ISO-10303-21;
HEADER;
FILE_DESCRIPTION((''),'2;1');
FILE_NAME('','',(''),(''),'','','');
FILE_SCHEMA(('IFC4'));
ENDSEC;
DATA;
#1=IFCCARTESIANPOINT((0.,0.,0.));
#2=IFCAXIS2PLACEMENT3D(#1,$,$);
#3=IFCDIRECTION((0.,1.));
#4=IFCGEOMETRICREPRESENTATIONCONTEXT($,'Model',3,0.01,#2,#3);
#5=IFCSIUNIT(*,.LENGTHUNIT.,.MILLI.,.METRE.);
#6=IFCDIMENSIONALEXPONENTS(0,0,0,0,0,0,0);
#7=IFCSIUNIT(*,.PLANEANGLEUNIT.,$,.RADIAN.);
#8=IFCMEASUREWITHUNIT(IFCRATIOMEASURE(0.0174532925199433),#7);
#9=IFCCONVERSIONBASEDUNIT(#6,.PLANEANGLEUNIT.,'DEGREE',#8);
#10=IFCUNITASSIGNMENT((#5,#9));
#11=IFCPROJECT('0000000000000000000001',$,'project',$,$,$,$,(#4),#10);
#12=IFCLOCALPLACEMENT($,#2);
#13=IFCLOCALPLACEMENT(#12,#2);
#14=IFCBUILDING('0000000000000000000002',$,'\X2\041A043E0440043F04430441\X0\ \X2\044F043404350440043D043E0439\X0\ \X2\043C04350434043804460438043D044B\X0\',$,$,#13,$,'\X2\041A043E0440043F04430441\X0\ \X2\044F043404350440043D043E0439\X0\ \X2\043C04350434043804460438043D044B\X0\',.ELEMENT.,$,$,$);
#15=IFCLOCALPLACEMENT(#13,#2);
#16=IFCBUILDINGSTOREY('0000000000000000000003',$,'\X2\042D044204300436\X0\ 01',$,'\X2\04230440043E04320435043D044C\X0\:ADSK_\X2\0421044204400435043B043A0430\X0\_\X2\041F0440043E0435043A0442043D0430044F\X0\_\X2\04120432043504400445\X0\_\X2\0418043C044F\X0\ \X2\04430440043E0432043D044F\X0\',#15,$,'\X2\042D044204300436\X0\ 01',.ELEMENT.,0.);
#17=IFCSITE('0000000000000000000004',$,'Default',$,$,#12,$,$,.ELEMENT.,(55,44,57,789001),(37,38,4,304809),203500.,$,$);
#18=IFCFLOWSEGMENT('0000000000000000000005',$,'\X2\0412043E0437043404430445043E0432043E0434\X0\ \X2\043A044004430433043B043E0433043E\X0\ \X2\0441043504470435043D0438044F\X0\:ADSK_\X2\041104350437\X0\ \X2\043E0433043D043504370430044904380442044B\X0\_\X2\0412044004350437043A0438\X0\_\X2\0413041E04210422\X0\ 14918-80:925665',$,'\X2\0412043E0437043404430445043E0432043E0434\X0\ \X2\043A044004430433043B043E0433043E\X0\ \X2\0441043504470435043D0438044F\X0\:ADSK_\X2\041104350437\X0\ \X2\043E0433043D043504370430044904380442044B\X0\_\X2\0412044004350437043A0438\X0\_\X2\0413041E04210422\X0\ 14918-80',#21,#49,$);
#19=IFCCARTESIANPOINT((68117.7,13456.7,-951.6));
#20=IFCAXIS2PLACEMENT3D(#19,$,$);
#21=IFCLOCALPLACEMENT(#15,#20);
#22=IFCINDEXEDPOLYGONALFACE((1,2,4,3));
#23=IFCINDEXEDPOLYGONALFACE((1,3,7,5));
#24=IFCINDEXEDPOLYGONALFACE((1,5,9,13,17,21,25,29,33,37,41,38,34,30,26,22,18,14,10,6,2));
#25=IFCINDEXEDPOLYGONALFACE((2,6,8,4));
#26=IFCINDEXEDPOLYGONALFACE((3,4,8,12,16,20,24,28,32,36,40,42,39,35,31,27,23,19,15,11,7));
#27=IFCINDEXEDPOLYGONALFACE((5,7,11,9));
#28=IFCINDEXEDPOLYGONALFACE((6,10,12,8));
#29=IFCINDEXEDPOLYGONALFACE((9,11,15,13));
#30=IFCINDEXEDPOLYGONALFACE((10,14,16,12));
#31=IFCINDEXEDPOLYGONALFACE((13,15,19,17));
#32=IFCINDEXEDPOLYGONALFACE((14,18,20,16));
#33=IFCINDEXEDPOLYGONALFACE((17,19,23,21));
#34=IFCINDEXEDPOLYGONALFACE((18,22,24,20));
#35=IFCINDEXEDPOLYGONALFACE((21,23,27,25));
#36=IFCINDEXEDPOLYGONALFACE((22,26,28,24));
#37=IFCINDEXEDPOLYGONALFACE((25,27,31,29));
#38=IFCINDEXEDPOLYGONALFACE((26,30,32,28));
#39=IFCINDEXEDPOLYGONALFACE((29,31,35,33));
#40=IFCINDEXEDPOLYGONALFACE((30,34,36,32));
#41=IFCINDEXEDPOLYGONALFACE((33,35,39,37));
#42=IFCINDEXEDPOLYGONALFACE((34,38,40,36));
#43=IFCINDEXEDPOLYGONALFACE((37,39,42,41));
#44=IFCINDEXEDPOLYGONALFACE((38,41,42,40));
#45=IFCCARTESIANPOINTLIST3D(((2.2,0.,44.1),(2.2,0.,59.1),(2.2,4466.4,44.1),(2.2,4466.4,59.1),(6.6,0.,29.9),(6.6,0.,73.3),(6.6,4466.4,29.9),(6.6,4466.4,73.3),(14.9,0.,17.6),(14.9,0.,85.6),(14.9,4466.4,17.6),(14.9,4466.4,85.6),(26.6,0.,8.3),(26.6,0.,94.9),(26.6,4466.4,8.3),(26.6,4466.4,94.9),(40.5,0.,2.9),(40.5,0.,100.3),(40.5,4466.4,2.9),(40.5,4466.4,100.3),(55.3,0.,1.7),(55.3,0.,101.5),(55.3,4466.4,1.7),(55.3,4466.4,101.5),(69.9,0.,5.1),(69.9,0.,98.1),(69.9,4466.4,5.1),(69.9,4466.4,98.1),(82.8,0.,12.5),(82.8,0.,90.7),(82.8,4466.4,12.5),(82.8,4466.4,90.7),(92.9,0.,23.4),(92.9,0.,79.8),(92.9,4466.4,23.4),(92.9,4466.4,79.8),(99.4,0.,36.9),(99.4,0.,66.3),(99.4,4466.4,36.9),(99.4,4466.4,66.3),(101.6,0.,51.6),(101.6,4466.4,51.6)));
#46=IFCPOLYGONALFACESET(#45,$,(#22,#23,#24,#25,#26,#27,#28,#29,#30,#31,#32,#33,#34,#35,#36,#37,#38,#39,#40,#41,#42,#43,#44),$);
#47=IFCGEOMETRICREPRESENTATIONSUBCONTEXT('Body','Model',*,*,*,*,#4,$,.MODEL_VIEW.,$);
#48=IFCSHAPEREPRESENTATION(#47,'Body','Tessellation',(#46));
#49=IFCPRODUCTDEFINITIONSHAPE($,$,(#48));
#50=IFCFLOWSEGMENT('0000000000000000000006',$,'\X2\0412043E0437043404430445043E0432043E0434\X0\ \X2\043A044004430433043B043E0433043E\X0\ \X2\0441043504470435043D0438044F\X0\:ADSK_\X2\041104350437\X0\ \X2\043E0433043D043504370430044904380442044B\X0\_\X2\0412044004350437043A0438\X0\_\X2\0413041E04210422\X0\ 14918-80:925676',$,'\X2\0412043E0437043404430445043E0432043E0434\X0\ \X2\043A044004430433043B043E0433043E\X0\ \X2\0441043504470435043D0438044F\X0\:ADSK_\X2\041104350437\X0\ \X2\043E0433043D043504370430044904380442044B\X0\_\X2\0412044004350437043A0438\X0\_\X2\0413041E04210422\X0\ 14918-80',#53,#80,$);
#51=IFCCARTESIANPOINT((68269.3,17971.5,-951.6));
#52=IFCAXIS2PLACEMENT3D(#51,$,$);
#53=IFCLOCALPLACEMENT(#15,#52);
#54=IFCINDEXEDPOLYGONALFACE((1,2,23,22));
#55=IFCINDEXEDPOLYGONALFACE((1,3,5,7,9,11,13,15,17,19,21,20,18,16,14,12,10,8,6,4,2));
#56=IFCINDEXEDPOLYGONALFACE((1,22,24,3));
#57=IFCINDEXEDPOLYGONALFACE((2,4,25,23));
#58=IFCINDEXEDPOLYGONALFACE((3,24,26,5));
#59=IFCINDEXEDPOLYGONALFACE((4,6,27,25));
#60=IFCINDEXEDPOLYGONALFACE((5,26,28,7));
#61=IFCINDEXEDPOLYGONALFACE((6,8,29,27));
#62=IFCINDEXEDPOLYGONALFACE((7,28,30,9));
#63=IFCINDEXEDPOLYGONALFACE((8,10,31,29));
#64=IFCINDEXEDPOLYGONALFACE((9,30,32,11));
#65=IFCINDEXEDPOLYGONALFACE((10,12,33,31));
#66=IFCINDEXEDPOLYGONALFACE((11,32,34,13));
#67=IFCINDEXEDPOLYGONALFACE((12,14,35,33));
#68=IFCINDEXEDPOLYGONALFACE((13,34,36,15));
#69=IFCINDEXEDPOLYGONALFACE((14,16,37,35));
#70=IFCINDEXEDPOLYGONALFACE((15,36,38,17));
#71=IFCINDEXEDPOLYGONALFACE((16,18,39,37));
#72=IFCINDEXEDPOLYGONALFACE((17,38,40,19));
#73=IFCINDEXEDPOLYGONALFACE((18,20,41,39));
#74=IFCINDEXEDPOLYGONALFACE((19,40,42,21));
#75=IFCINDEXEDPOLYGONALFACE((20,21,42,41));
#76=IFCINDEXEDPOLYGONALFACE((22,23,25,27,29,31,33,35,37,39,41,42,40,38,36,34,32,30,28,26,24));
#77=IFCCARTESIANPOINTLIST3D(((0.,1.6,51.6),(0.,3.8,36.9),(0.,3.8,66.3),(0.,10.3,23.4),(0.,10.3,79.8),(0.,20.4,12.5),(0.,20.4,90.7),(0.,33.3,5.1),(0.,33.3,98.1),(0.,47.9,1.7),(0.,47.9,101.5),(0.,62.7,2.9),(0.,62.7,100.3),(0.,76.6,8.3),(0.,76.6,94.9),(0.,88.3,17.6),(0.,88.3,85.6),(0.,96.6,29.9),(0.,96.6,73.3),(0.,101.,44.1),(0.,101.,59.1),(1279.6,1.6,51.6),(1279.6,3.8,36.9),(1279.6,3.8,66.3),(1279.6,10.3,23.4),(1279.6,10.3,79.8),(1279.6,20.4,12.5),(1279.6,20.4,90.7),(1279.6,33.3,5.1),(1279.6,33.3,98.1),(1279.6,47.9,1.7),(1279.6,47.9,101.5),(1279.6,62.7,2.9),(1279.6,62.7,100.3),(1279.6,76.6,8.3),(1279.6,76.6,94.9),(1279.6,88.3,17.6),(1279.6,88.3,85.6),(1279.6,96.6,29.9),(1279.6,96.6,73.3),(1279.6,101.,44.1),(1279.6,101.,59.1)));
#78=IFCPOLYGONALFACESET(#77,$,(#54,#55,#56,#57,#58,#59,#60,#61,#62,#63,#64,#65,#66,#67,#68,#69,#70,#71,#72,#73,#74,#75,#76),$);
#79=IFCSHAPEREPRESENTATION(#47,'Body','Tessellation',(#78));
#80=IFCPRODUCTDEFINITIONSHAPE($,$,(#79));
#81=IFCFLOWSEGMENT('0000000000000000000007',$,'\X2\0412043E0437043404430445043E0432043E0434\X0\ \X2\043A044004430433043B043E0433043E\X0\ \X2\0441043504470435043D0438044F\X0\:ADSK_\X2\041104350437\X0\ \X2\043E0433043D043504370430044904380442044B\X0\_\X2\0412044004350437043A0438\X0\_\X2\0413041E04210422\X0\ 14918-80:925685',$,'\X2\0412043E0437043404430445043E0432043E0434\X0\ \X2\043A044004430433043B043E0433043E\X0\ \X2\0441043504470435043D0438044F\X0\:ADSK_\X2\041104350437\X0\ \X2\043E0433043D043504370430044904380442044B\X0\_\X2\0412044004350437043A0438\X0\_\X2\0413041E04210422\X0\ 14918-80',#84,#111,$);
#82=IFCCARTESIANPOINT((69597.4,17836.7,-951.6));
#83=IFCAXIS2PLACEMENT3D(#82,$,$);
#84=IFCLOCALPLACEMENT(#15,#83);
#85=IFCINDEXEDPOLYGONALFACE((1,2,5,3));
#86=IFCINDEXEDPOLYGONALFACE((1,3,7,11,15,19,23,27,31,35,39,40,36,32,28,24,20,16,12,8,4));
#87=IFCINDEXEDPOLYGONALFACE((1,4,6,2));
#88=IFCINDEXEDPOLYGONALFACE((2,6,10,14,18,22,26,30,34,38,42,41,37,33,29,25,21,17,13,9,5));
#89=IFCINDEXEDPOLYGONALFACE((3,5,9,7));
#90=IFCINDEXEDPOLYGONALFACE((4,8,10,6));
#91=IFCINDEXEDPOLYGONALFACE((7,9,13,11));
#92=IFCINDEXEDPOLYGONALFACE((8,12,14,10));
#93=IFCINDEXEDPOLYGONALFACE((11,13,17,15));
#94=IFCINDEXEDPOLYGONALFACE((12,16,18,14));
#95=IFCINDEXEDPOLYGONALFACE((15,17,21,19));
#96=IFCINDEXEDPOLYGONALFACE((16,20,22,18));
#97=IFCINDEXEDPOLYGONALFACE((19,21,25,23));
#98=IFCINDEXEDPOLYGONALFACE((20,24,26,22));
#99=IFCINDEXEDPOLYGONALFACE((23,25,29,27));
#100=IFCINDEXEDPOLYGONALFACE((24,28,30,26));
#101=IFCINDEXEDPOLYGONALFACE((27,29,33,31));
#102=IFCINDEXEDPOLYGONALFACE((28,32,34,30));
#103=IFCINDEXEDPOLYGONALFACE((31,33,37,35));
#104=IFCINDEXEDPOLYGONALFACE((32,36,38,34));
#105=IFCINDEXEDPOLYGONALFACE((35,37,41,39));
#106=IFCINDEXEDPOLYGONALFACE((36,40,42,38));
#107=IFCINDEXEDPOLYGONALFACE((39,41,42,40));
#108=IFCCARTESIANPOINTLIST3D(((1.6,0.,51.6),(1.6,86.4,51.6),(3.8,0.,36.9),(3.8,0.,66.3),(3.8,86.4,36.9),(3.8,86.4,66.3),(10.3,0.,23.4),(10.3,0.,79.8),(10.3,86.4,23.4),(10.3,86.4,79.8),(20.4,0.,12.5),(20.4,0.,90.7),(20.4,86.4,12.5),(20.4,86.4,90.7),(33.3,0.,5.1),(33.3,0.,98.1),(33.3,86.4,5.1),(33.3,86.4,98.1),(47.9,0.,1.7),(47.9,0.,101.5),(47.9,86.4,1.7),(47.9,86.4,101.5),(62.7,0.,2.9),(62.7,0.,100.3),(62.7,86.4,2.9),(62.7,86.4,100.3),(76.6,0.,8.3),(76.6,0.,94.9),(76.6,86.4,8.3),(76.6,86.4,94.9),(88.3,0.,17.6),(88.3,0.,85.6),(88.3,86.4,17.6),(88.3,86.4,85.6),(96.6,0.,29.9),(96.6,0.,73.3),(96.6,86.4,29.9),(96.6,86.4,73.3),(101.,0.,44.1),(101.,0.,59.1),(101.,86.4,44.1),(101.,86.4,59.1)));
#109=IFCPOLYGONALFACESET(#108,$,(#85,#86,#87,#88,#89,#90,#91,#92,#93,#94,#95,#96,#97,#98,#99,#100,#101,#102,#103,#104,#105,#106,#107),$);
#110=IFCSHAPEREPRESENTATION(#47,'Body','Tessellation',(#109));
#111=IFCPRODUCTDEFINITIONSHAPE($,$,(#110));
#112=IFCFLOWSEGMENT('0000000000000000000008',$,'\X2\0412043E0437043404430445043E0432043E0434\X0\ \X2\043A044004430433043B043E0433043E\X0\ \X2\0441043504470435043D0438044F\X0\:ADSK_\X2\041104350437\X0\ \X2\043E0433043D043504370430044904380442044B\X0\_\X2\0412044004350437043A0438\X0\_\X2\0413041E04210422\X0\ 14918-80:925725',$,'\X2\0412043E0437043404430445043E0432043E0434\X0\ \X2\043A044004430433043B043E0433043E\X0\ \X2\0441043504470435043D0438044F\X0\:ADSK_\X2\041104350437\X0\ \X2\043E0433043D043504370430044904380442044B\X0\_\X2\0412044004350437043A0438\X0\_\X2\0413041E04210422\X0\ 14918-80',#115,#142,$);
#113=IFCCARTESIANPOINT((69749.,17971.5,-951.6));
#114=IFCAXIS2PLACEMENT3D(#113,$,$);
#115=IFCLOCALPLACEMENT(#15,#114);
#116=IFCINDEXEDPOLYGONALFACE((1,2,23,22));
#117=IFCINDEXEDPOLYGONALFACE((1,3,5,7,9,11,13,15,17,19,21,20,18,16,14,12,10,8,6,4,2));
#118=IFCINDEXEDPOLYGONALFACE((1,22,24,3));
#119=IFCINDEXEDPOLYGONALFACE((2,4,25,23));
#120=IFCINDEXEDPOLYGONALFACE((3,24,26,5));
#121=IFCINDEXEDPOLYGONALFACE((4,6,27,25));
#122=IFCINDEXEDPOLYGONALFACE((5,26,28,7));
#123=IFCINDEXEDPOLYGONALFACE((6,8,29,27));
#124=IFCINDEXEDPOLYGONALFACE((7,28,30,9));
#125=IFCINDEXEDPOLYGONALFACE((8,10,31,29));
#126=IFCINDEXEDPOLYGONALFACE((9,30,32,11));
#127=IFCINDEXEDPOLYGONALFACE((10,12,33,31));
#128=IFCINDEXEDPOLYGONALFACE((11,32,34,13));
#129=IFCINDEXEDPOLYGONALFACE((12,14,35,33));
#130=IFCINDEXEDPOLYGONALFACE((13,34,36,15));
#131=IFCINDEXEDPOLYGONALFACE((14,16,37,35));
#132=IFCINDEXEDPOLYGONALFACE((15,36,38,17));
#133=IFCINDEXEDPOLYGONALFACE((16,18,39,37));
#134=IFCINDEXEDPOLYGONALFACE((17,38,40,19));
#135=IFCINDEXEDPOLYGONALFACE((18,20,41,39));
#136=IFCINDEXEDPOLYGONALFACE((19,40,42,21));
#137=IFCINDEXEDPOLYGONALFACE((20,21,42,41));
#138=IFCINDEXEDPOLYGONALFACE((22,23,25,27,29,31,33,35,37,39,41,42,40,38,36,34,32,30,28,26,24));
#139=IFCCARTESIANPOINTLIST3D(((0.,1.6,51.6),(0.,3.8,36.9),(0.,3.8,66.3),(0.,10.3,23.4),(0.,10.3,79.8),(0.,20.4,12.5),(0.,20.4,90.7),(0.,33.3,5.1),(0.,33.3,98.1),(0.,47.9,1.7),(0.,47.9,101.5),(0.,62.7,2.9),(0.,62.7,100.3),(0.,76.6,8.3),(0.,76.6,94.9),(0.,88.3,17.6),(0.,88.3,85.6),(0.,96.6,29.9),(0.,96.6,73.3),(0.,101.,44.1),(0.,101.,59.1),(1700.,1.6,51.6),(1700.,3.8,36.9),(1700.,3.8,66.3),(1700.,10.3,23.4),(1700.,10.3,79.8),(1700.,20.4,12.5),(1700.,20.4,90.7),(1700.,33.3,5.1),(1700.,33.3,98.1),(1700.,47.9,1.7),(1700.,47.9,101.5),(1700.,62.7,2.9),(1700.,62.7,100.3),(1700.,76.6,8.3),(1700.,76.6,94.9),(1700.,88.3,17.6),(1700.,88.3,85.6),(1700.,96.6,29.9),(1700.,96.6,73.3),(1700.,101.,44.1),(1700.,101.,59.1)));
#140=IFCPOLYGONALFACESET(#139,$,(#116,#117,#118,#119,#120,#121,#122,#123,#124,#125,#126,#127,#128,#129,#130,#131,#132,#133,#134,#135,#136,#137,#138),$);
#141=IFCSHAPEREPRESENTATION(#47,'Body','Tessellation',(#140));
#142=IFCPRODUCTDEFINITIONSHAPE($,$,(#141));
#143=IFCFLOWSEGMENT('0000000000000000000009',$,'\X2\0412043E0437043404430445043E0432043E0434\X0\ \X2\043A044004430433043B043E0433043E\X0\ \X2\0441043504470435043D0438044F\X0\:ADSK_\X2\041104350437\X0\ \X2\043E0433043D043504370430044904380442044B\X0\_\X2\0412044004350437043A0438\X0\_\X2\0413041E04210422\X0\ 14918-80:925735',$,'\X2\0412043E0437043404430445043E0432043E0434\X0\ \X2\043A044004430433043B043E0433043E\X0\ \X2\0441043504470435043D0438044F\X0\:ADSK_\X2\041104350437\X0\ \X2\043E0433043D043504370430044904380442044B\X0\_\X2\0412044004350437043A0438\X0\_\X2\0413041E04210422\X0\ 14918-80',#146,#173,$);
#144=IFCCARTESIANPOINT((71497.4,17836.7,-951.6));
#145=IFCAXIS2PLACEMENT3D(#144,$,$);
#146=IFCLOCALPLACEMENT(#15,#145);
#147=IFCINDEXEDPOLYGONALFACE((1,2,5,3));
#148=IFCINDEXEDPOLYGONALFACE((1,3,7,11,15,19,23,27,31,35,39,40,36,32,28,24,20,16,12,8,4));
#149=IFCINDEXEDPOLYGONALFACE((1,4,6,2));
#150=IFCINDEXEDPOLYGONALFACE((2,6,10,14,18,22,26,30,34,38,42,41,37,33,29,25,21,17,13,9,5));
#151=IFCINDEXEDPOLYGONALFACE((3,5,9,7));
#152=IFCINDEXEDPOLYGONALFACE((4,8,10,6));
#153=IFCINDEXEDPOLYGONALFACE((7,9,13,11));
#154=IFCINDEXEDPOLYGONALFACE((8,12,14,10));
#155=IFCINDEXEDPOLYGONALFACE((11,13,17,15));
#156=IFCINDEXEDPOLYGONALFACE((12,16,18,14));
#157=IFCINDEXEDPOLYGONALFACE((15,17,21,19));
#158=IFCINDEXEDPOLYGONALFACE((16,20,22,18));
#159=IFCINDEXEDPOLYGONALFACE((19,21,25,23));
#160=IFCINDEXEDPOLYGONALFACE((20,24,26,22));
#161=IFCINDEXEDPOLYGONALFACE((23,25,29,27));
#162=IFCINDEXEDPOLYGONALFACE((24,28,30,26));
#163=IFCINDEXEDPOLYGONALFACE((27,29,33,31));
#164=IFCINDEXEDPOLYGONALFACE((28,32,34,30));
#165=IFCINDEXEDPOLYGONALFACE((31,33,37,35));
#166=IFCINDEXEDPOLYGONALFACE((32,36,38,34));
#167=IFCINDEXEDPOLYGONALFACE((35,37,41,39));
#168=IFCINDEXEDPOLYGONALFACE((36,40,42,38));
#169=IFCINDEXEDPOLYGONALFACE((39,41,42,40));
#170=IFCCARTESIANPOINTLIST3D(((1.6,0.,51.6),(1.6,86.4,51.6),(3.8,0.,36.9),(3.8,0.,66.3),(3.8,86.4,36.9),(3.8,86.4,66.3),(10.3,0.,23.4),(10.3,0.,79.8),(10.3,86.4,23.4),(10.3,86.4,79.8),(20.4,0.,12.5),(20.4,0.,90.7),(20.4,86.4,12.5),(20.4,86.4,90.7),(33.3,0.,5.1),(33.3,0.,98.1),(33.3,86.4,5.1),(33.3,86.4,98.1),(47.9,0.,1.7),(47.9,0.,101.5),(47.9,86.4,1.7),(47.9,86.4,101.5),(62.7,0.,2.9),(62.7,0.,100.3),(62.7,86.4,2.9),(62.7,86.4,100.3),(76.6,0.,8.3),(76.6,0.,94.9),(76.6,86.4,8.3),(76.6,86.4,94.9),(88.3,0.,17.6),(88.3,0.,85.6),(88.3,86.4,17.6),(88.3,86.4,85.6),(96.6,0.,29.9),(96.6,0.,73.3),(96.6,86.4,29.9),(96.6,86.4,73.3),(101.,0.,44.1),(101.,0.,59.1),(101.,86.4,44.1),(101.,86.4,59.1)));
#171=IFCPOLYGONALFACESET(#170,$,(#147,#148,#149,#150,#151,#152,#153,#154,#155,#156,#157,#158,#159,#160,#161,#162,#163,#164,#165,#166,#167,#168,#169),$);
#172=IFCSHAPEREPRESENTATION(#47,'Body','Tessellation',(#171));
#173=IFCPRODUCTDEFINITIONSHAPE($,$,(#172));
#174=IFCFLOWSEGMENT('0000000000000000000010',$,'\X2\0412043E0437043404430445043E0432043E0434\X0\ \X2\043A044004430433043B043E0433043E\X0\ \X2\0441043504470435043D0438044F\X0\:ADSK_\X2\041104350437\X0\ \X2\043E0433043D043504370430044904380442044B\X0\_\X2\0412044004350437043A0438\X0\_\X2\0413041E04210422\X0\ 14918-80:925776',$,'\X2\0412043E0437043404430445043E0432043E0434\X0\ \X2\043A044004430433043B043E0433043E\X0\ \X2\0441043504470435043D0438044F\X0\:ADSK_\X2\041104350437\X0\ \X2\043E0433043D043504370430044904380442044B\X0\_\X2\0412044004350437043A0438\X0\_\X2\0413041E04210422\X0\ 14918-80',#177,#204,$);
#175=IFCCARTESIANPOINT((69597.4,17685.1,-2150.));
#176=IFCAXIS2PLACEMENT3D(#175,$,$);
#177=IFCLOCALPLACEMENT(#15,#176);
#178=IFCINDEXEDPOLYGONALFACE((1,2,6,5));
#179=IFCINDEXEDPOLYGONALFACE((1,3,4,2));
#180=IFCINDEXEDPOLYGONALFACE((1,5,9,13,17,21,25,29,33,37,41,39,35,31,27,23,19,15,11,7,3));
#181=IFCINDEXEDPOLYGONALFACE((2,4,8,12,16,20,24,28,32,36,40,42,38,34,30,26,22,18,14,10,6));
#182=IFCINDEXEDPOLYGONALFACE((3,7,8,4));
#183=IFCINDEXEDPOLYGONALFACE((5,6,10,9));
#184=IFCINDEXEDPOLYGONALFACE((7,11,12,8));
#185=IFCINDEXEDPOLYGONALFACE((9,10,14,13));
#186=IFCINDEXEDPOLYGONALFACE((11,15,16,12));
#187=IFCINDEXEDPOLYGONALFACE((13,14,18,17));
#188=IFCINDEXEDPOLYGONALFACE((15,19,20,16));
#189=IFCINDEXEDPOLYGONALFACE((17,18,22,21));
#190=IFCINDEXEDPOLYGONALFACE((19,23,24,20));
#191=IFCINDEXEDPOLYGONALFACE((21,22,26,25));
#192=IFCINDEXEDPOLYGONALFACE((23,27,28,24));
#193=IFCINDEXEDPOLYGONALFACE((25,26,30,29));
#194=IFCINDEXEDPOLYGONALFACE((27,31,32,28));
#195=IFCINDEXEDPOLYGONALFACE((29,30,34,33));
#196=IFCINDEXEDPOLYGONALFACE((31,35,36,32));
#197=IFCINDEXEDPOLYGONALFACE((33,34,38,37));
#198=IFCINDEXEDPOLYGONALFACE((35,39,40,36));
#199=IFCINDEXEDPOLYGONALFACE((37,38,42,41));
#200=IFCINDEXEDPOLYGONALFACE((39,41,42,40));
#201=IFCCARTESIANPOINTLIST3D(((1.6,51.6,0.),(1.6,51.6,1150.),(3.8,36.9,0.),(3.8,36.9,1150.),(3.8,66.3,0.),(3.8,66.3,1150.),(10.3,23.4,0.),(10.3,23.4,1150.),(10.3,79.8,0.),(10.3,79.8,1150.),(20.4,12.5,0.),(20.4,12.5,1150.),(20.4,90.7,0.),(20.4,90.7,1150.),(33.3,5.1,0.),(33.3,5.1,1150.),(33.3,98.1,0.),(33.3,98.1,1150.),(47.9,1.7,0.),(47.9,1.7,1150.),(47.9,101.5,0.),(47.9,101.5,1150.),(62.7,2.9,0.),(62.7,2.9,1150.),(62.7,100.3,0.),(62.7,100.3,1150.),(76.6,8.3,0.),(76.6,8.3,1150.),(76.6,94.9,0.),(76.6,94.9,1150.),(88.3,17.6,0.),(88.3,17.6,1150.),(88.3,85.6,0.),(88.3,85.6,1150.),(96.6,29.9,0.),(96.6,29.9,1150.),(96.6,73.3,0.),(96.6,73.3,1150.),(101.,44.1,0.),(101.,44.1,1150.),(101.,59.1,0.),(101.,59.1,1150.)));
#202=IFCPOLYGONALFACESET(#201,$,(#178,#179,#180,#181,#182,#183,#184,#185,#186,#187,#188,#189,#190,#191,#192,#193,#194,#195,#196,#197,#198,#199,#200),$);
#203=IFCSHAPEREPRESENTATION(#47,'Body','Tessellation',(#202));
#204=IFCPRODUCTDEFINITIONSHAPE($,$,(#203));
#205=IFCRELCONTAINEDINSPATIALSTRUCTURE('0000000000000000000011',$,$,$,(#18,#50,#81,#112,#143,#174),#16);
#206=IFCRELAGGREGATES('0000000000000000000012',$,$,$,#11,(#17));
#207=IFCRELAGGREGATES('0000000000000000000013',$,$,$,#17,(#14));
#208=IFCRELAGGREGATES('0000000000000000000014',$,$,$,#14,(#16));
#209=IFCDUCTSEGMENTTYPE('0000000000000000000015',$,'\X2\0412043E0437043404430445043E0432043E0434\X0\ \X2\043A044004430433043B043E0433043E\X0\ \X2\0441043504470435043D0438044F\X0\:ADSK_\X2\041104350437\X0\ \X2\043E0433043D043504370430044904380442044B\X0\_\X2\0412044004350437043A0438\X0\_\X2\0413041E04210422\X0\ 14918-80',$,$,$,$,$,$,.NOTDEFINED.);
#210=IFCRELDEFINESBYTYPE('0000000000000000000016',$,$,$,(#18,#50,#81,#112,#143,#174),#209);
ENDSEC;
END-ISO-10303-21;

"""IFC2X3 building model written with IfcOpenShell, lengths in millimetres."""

from ifc_helpers import new_model, entity, si_unit, converted_unit, direction, frame, origin, origin_2d_with_axis, place, context, subcontext, project, spatial, circle, extrude, type_object, element, save


model = new_model("IFC2X3")

# Units and contexts
model_context = context("Model", 3, precision=0.01, world=origin(), true_north=direction((0.0, 1.0)))
body_context = subcontext(model_context, "Body", "Model", "MODEL_VIEW")
ifc_project = project(units=[si_unit("LENGTHUNIT", "METRE", prefix="MILLI"), converted_unit("PLANEANGLEUNIT", "DEGREE", entity("IfcRatioMeasure", 0.0174532925199433), si_unit("PLANEANGLEUNIT", "RADIAN"), dimensions=[0, 0, 0, 0, 0, 0, 0])], contexts=[model_context])

# Site, building, storey
site_placement = place(None, origin())
site = spatial("IfcSite", under=ifc_project, at=site_placement, Name="Default", CompositionType="ELEMENT", RefLatitude=(55, 44, 57, 789001), RefLongitude=(37, 38, 4, 304809), RefElevation=203500.0)
building_placement = place(site_placement, origin())
building = spatial("IfcBuilding", under=site, at=building_placement, Name="Корпус ядерной медицины", LongName="Корпус ядерной медицины", CompositionType="ELEMENT")
storey_placement = place(building_placement, origin())
storey = spatial("IfcBuildingStorey", under=building, at=storey_placement, Name="Этаж 01", ObjectType="Уровень:ADSK_Стрелка_Проектная_Вверх_Имя уровня", LongName="Этаж 01", CompositionType="ELEMENT", Elevation=0.0)

# Flow segments
duct_segment_type = type_object("IfcDuctSegmentType", Name="Воздуховод круглого сечения:ADSK_Без огнезащиты_Врезки_ГОСТ 14918-80", PredefinedType="NOTDEFINED")
flow_segment_1_placement = place(storey_placement, frame((68117.7, 13456.7, -951.6)))
element("IfcFlowSegment", 1, at=flow_segment_1_placement, inside=storey, type_object=duct_segment_type, Name="Воздуховод круглого сечения:ADSK_Без огнезащиты_Врезки_ГОСТ 14918-80:925665", ObjectType="Воздуховод круглого сечения:ADSK_Без огнезащиты_Врезки_ГОСТ 14918-80", context=body_context, shape_type="SweptSolid", body=[
    extrude(circle(Radius=50.0, at=origin_2d_with_axis()), frame((51.6, 0.0, 51.6), z_axis=(0.0, 1.0, 0.0), x_axis=(1.0, 0.0, 0.0)), (0.0, 0.0, 1.0), 4466.4),
])
flow_segment_2_placement = place(storey_placement, frame((68269.3, 17971.5, -951.6)))
element("IfcFlowSegment", 2, at=flow_segment_2_placement, inside=storey, type_object=duct_segment_type, Name="Воздуховод круглого сечения:ADSK_Без огнезащиты_Врезки_ГОСТ 14918-80:925676", ObjectType="Воздуховод круглого сечения:ADSK_Без огнезащиты_Врезки_ГОСТ 14918-80", context=body_context, shape_type="SweptSolid", body=[
    extrude(circle(Radius=50.0, at=origin_2d_with_axis()), frame((0.0, 51.6, 51.6), z_axis=(1.0, 0.0, 0.0), x_axis=(0.0, -1.0, 0.0)), (0.0, 0.0, 1.0), 1279.6),
])
flow_segment_3_placement = place(storey_placement, frame((69597.4, 17836.7, -951.6)))
element("IfcFlowSegment", 3, at=flow_segment_3_placement, inside=storey, type_object=duct_segment_type, Name="Воздуховод круглого сечения:ADSK_Без огнезащиты_Врезки_ГОСТ 14918-80:925685", ObjectType="Воздуховод круглого сечения:ADSK_Без огнезащиты_Врезки_ГОСТ 14918-80", context=body_context, shape_type="SweptSolid", body=[
    extrude(circle(Radius=50.0, at=origin_2d_with_axis()), frame((51.6, 0.0, 51.6), z_axis=(0.0, 1.0, 0.0), x_axis=(-1.0, 0.0, 0.0)), (0.0, 0.0, 1.0), 86.4),
])
flow_segment_4_placement = place(storey_placement, frame((69749.0, 17971.5, -951.6)))
element("IfcFlowSegment", 4, at=flow_segment_4_placement, inside=storey, type_object=duct_segment_type, Name="Воздуховод круглого сечения:ADSK_Без огнезащиты_Врезки_ГОСТ 14918-80:925725", ObjectType="Воздуховод круглого сечения:ADSK_Без огнезащиты_Врезки_ГОСТ 14918-80", context=body_context, shape_type="SweptSolid", body=[
    extrude(circle(Radius=50.0, at=origin_2d_with_axis()), frame((0.0, 51.6, 51.6), z_axis=(1.0, 0.0, 0.0), x_axis=(0.0, -1.0, 0.0)), (0.0, 0.0, 1.0), 1700.0),
])
flow_segment_5_placement = place(storey_placement, frame((71497.4, 17836.7, -951.6)))
element("IfcFlowSegment", 5, at=flow_segment_5_placement, inside=storey, type_object=duct_segment_type, Name="Воздуховод круглого сечения:ADSK_Без огнезащиты_Врезки_ГОСТ 14918-80:925735", ObjectType="Воздуховод круглого сечения:ADSK_Без огнезащиты_Врезки_ГОСТ 14918-80", context=body_context, shape_type="SweptSolid", body=[
    extrude(circle(Radius=50.0, at=origin_2d_with_axis()), frame((51.6, 0.0, 51.6), z_axis=(0.0, 1.0, 0.0), x_axis=(-1.0, 0.0, 0.0)), (0.0, 0.0, 1.0), 86.4),
])
flow_segment_6_placement = place(storey_placement, frame((69597.4, 17685.1, -2150.0)))
element("IfcFlowSegment", 6, at=flow_segment_6_placement, inside=storey, type_object=duct_segment_type, Name="Воздуховод круглого сечения:ADSK_Без огнезащиты_Врезки_ГОСТ 14918-80:925776", ObjectType="Воздуховод круглого сечения:ADSK_Без огнезащиты_Врезки_ГОСТ 14918-80", context=body_context, shape_type="SweptSolid", body=[
    extrude(circle(Radius=50.0, at=origin_2d_with_axis()), frame((51.6, 51.6, 0.0), z_axis=(0.0, 0.0, 1.0), x_axis=(-1.0, 0.0, 0.0)), (0.0, 0.0, 1.0), 1150.0),
])

save(model, "model.ifc")
